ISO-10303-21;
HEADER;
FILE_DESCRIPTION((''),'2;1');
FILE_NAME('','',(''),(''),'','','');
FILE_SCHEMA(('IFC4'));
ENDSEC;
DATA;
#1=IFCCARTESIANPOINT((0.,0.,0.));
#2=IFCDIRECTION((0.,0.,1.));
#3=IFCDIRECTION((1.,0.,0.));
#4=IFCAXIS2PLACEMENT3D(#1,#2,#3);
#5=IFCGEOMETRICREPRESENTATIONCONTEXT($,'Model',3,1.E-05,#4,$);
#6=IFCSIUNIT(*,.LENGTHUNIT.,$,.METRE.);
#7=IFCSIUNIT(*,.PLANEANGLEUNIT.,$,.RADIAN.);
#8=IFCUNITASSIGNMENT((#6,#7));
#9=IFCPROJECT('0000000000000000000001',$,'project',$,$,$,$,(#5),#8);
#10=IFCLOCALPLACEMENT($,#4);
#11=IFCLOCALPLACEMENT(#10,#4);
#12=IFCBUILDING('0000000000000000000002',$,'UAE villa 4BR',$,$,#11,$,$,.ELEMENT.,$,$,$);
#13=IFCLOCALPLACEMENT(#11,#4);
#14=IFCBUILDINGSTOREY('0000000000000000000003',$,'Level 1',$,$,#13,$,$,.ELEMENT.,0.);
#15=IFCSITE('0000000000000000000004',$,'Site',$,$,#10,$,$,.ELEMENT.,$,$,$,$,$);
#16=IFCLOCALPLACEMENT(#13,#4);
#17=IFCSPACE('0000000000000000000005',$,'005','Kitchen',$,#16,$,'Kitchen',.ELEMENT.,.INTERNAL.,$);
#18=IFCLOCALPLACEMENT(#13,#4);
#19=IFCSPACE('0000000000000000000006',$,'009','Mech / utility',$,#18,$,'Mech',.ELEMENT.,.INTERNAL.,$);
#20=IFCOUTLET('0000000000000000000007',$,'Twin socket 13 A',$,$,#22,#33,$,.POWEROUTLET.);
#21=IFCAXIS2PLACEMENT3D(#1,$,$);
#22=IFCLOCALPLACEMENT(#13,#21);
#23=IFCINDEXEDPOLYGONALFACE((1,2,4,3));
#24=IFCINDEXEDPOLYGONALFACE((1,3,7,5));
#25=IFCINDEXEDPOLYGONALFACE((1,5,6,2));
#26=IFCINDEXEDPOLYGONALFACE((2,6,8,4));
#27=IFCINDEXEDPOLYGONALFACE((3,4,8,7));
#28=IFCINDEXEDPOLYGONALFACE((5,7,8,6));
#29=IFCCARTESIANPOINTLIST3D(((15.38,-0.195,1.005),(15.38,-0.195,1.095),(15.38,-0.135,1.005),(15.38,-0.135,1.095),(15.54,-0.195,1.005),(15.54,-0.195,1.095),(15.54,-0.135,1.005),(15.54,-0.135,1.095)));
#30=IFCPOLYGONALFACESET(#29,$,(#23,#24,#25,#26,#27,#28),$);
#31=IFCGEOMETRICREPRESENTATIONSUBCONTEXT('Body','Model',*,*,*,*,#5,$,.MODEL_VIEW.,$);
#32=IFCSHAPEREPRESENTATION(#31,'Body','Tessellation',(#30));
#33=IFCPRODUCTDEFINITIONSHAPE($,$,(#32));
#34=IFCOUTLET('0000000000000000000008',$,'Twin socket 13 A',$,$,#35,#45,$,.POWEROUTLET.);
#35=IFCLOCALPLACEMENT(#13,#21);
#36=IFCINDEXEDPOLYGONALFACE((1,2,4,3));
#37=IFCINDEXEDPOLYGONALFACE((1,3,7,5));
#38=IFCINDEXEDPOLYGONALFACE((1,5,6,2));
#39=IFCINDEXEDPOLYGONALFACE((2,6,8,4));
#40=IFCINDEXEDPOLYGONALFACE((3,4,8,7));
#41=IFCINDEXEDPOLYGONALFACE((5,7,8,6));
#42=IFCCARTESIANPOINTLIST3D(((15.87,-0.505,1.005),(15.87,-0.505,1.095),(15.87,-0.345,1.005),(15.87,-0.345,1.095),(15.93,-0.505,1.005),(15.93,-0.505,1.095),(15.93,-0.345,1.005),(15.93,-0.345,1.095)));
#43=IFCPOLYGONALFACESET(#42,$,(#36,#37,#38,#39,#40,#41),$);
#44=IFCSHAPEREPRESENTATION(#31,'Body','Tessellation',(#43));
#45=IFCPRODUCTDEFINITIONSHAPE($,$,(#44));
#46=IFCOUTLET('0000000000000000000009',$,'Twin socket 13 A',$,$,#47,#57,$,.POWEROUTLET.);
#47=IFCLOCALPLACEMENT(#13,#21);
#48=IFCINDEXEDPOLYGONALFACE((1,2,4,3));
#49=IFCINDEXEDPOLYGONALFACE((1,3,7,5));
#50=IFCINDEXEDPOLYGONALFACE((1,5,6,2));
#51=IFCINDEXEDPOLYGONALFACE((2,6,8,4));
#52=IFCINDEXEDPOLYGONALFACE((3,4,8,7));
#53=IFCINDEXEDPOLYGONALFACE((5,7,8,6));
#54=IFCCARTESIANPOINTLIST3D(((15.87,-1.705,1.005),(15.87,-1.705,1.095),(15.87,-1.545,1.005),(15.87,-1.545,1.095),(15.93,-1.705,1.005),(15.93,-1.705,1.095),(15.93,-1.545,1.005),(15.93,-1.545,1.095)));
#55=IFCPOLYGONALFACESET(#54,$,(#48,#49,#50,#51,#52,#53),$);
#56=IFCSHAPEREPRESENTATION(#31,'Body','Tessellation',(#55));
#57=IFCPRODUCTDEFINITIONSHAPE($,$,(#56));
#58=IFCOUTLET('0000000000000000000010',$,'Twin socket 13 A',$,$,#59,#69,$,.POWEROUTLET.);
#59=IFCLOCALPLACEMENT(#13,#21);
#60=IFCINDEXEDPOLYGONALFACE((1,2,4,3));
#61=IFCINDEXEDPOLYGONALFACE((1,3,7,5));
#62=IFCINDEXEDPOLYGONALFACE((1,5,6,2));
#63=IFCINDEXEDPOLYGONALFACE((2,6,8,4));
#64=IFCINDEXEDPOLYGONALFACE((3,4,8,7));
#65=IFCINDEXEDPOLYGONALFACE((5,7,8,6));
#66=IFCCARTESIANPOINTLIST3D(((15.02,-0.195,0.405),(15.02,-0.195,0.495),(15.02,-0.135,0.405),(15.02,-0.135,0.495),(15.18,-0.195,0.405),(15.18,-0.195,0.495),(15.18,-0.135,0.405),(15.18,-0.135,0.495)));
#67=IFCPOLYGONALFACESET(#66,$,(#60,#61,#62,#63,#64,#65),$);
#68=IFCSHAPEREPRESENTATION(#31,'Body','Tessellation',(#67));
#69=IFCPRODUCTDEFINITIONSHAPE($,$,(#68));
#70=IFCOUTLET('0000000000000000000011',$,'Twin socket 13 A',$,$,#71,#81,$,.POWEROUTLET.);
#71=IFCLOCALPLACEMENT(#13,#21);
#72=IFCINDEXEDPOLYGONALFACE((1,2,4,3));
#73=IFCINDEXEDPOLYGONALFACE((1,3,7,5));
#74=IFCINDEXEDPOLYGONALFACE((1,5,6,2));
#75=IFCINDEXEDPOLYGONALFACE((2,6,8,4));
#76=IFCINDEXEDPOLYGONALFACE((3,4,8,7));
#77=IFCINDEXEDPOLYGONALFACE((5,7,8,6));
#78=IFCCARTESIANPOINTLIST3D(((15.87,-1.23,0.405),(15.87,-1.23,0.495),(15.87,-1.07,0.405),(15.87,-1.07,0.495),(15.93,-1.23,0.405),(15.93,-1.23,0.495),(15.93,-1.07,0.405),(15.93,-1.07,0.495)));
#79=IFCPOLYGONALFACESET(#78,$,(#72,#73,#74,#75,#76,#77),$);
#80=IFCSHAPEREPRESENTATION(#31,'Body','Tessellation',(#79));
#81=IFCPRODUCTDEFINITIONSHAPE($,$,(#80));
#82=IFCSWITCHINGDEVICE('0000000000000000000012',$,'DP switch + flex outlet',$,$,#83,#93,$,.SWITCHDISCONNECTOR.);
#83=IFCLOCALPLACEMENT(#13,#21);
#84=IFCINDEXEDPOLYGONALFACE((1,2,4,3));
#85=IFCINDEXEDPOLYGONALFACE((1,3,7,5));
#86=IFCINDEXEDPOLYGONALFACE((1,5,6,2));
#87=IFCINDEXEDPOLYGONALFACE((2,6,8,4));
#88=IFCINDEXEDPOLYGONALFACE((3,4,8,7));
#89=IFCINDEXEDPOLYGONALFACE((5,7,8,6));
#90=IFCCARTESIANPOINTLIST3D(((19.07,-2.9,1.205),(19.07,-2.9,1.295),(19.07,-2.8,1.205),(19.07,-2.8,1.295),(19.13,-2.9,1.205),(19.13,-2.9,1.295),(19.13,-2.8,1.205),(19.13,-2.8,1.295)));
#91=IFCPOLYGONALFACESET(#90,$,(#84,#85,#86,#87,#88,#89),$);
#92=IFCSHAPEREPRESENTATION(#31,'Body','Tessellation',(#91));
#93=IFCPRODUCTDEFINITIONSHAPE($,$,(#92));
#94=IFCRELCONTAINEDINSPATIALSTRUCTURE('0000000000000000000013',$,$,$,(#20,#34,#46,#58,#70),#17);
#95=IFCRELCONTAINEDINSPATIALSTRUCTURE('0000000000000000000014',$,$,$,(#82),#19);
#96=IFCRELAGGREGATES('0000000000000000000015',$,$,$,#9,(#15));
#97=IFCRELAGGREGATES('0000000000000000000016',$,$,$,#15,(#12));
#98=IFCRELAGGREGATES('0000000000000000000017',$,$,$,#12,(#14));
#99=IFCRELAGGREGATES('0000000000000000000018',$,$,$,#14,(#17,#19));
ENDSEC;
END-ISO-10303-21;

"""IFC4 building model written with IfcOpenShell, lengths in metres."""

from ifc_helpers import new_model, si_unit, frame, origin, origin_with_axes, origin_2d, place, context, subcontext, project, spatial, rectangle, extrude, element, save


model = new_model("IFC4")

# Units and contexts
model_context = context("Model", 3, precision=1e-05, world=origin_with_axes())
body_context = subcontext(model_context, "Body", "Model", "MODEL_VIEW")
ifc_project = project(units=[si_unit("LENGTHUNIT", "METRE"), si_unit("PLANEANGLEUNIT", "RADIAN")], contexts=[model_context])

# Site, building, storey
site_placement = place(None, origin_with_axes())
site = spatial("IfcSite", under=ifc_project, at=site_placement, Name="Site", CompositionType="ELEMENT")
building_placement = place(site_placement, origin_with_axes())
building = spatial("IfcBuilding", under=site, at=building_placement, Name="UAE villa 4BR", CompositionType="ELEMENT")
storey_placement = place(building_placement, origin_with_axes())
storey = spatial("IfcBuildingStorey", under=building, at=storey_placement, Name="Level 1", CompositionType="ELEMENT", Elevation=0.0)

# Shared definitions
space_1_placement = place(storey_placement, origin_with_axes())
space_1 = spatial("IfcSpace", under=storey, at=space_1_placement, Name="005", Description="Kitchen", LongName="Kitchen", CompositionType="ELEMENT", PredefinedType="INTERNAL")

# Shared definitions
space_2_placement = place(storey_placement, origin_with_axes())
space_2 = spatial("IfcSpace", under=storey, at=space_2_placement, Name="009", Description="Mech / utility", LongName="Mech", CompositionType="ELEMENT", PredefinedType="INTERNAL")

# Outlets
for number, where, z_axis, x_axis, name in (
    (1, (15.46, -0.165, 1.005), (0.0, 0.0, 1.0), (1.0, 0.0, 0.0), "Twin socket 13 A"),
    (2, (15.9, -0.425, 1.005), (0.0, 0.0, 1.0), (0.0, -1.0, 0.0), "Twin socket 13 A"),
    (3, (15.9, -1.625, 1.005), (0.0, 0.0, 1.0), (0.0, -1.0, 0.0), "Twin socket 13 A"),
    (4, (15.1, -0.165, 0.405), (0.0, 0.0, 1.0), (1.0, 0.0, 0.0), "Twin socket 13 A"),
    (5, (15.9, -1.15, 0.405), (0.0, 0.0, 1.0), (0.0, -1.0, 0.0), "Twin socket 13 A"),
):
    element("IfcOutlet", number, at=place(storey_placement, frame(where, z_axis=z_axis, x_axis=x_axis)), inside=space_1, Name=name, PredefinedType="POWEROUTLET", context=body_context, shape_type="SweptSolid", body=[
        extrude(rectangle(XDim=0.16, YDim=0.06, at=origin_2d()), origin(), (0.0, 0.0, 1.0), 0.09),
    ])

# Switching device
switching_device_placement = place(storey_placement, frame((19.1, -2.85, 1.205), z_axis=(0.0, 0.0, 1.0), x_axis=(0.0, 1.0, 0.0)))
element("IfcSwitchingDevice", 6, at=switching_device_placement, inside=space_2, Name="DP switch + flex outlet", PredefinedType="SWITCHDISCONNECTOR", context=body_context, shape_type="SweptSolid", body=[
    extrude(rectangle(XDim=0.1, YDim=0.06, at=origin_2d()), origin(), (0.0, 0.0, 1.0), 0.09),
])

save(model, "model.ifc")
